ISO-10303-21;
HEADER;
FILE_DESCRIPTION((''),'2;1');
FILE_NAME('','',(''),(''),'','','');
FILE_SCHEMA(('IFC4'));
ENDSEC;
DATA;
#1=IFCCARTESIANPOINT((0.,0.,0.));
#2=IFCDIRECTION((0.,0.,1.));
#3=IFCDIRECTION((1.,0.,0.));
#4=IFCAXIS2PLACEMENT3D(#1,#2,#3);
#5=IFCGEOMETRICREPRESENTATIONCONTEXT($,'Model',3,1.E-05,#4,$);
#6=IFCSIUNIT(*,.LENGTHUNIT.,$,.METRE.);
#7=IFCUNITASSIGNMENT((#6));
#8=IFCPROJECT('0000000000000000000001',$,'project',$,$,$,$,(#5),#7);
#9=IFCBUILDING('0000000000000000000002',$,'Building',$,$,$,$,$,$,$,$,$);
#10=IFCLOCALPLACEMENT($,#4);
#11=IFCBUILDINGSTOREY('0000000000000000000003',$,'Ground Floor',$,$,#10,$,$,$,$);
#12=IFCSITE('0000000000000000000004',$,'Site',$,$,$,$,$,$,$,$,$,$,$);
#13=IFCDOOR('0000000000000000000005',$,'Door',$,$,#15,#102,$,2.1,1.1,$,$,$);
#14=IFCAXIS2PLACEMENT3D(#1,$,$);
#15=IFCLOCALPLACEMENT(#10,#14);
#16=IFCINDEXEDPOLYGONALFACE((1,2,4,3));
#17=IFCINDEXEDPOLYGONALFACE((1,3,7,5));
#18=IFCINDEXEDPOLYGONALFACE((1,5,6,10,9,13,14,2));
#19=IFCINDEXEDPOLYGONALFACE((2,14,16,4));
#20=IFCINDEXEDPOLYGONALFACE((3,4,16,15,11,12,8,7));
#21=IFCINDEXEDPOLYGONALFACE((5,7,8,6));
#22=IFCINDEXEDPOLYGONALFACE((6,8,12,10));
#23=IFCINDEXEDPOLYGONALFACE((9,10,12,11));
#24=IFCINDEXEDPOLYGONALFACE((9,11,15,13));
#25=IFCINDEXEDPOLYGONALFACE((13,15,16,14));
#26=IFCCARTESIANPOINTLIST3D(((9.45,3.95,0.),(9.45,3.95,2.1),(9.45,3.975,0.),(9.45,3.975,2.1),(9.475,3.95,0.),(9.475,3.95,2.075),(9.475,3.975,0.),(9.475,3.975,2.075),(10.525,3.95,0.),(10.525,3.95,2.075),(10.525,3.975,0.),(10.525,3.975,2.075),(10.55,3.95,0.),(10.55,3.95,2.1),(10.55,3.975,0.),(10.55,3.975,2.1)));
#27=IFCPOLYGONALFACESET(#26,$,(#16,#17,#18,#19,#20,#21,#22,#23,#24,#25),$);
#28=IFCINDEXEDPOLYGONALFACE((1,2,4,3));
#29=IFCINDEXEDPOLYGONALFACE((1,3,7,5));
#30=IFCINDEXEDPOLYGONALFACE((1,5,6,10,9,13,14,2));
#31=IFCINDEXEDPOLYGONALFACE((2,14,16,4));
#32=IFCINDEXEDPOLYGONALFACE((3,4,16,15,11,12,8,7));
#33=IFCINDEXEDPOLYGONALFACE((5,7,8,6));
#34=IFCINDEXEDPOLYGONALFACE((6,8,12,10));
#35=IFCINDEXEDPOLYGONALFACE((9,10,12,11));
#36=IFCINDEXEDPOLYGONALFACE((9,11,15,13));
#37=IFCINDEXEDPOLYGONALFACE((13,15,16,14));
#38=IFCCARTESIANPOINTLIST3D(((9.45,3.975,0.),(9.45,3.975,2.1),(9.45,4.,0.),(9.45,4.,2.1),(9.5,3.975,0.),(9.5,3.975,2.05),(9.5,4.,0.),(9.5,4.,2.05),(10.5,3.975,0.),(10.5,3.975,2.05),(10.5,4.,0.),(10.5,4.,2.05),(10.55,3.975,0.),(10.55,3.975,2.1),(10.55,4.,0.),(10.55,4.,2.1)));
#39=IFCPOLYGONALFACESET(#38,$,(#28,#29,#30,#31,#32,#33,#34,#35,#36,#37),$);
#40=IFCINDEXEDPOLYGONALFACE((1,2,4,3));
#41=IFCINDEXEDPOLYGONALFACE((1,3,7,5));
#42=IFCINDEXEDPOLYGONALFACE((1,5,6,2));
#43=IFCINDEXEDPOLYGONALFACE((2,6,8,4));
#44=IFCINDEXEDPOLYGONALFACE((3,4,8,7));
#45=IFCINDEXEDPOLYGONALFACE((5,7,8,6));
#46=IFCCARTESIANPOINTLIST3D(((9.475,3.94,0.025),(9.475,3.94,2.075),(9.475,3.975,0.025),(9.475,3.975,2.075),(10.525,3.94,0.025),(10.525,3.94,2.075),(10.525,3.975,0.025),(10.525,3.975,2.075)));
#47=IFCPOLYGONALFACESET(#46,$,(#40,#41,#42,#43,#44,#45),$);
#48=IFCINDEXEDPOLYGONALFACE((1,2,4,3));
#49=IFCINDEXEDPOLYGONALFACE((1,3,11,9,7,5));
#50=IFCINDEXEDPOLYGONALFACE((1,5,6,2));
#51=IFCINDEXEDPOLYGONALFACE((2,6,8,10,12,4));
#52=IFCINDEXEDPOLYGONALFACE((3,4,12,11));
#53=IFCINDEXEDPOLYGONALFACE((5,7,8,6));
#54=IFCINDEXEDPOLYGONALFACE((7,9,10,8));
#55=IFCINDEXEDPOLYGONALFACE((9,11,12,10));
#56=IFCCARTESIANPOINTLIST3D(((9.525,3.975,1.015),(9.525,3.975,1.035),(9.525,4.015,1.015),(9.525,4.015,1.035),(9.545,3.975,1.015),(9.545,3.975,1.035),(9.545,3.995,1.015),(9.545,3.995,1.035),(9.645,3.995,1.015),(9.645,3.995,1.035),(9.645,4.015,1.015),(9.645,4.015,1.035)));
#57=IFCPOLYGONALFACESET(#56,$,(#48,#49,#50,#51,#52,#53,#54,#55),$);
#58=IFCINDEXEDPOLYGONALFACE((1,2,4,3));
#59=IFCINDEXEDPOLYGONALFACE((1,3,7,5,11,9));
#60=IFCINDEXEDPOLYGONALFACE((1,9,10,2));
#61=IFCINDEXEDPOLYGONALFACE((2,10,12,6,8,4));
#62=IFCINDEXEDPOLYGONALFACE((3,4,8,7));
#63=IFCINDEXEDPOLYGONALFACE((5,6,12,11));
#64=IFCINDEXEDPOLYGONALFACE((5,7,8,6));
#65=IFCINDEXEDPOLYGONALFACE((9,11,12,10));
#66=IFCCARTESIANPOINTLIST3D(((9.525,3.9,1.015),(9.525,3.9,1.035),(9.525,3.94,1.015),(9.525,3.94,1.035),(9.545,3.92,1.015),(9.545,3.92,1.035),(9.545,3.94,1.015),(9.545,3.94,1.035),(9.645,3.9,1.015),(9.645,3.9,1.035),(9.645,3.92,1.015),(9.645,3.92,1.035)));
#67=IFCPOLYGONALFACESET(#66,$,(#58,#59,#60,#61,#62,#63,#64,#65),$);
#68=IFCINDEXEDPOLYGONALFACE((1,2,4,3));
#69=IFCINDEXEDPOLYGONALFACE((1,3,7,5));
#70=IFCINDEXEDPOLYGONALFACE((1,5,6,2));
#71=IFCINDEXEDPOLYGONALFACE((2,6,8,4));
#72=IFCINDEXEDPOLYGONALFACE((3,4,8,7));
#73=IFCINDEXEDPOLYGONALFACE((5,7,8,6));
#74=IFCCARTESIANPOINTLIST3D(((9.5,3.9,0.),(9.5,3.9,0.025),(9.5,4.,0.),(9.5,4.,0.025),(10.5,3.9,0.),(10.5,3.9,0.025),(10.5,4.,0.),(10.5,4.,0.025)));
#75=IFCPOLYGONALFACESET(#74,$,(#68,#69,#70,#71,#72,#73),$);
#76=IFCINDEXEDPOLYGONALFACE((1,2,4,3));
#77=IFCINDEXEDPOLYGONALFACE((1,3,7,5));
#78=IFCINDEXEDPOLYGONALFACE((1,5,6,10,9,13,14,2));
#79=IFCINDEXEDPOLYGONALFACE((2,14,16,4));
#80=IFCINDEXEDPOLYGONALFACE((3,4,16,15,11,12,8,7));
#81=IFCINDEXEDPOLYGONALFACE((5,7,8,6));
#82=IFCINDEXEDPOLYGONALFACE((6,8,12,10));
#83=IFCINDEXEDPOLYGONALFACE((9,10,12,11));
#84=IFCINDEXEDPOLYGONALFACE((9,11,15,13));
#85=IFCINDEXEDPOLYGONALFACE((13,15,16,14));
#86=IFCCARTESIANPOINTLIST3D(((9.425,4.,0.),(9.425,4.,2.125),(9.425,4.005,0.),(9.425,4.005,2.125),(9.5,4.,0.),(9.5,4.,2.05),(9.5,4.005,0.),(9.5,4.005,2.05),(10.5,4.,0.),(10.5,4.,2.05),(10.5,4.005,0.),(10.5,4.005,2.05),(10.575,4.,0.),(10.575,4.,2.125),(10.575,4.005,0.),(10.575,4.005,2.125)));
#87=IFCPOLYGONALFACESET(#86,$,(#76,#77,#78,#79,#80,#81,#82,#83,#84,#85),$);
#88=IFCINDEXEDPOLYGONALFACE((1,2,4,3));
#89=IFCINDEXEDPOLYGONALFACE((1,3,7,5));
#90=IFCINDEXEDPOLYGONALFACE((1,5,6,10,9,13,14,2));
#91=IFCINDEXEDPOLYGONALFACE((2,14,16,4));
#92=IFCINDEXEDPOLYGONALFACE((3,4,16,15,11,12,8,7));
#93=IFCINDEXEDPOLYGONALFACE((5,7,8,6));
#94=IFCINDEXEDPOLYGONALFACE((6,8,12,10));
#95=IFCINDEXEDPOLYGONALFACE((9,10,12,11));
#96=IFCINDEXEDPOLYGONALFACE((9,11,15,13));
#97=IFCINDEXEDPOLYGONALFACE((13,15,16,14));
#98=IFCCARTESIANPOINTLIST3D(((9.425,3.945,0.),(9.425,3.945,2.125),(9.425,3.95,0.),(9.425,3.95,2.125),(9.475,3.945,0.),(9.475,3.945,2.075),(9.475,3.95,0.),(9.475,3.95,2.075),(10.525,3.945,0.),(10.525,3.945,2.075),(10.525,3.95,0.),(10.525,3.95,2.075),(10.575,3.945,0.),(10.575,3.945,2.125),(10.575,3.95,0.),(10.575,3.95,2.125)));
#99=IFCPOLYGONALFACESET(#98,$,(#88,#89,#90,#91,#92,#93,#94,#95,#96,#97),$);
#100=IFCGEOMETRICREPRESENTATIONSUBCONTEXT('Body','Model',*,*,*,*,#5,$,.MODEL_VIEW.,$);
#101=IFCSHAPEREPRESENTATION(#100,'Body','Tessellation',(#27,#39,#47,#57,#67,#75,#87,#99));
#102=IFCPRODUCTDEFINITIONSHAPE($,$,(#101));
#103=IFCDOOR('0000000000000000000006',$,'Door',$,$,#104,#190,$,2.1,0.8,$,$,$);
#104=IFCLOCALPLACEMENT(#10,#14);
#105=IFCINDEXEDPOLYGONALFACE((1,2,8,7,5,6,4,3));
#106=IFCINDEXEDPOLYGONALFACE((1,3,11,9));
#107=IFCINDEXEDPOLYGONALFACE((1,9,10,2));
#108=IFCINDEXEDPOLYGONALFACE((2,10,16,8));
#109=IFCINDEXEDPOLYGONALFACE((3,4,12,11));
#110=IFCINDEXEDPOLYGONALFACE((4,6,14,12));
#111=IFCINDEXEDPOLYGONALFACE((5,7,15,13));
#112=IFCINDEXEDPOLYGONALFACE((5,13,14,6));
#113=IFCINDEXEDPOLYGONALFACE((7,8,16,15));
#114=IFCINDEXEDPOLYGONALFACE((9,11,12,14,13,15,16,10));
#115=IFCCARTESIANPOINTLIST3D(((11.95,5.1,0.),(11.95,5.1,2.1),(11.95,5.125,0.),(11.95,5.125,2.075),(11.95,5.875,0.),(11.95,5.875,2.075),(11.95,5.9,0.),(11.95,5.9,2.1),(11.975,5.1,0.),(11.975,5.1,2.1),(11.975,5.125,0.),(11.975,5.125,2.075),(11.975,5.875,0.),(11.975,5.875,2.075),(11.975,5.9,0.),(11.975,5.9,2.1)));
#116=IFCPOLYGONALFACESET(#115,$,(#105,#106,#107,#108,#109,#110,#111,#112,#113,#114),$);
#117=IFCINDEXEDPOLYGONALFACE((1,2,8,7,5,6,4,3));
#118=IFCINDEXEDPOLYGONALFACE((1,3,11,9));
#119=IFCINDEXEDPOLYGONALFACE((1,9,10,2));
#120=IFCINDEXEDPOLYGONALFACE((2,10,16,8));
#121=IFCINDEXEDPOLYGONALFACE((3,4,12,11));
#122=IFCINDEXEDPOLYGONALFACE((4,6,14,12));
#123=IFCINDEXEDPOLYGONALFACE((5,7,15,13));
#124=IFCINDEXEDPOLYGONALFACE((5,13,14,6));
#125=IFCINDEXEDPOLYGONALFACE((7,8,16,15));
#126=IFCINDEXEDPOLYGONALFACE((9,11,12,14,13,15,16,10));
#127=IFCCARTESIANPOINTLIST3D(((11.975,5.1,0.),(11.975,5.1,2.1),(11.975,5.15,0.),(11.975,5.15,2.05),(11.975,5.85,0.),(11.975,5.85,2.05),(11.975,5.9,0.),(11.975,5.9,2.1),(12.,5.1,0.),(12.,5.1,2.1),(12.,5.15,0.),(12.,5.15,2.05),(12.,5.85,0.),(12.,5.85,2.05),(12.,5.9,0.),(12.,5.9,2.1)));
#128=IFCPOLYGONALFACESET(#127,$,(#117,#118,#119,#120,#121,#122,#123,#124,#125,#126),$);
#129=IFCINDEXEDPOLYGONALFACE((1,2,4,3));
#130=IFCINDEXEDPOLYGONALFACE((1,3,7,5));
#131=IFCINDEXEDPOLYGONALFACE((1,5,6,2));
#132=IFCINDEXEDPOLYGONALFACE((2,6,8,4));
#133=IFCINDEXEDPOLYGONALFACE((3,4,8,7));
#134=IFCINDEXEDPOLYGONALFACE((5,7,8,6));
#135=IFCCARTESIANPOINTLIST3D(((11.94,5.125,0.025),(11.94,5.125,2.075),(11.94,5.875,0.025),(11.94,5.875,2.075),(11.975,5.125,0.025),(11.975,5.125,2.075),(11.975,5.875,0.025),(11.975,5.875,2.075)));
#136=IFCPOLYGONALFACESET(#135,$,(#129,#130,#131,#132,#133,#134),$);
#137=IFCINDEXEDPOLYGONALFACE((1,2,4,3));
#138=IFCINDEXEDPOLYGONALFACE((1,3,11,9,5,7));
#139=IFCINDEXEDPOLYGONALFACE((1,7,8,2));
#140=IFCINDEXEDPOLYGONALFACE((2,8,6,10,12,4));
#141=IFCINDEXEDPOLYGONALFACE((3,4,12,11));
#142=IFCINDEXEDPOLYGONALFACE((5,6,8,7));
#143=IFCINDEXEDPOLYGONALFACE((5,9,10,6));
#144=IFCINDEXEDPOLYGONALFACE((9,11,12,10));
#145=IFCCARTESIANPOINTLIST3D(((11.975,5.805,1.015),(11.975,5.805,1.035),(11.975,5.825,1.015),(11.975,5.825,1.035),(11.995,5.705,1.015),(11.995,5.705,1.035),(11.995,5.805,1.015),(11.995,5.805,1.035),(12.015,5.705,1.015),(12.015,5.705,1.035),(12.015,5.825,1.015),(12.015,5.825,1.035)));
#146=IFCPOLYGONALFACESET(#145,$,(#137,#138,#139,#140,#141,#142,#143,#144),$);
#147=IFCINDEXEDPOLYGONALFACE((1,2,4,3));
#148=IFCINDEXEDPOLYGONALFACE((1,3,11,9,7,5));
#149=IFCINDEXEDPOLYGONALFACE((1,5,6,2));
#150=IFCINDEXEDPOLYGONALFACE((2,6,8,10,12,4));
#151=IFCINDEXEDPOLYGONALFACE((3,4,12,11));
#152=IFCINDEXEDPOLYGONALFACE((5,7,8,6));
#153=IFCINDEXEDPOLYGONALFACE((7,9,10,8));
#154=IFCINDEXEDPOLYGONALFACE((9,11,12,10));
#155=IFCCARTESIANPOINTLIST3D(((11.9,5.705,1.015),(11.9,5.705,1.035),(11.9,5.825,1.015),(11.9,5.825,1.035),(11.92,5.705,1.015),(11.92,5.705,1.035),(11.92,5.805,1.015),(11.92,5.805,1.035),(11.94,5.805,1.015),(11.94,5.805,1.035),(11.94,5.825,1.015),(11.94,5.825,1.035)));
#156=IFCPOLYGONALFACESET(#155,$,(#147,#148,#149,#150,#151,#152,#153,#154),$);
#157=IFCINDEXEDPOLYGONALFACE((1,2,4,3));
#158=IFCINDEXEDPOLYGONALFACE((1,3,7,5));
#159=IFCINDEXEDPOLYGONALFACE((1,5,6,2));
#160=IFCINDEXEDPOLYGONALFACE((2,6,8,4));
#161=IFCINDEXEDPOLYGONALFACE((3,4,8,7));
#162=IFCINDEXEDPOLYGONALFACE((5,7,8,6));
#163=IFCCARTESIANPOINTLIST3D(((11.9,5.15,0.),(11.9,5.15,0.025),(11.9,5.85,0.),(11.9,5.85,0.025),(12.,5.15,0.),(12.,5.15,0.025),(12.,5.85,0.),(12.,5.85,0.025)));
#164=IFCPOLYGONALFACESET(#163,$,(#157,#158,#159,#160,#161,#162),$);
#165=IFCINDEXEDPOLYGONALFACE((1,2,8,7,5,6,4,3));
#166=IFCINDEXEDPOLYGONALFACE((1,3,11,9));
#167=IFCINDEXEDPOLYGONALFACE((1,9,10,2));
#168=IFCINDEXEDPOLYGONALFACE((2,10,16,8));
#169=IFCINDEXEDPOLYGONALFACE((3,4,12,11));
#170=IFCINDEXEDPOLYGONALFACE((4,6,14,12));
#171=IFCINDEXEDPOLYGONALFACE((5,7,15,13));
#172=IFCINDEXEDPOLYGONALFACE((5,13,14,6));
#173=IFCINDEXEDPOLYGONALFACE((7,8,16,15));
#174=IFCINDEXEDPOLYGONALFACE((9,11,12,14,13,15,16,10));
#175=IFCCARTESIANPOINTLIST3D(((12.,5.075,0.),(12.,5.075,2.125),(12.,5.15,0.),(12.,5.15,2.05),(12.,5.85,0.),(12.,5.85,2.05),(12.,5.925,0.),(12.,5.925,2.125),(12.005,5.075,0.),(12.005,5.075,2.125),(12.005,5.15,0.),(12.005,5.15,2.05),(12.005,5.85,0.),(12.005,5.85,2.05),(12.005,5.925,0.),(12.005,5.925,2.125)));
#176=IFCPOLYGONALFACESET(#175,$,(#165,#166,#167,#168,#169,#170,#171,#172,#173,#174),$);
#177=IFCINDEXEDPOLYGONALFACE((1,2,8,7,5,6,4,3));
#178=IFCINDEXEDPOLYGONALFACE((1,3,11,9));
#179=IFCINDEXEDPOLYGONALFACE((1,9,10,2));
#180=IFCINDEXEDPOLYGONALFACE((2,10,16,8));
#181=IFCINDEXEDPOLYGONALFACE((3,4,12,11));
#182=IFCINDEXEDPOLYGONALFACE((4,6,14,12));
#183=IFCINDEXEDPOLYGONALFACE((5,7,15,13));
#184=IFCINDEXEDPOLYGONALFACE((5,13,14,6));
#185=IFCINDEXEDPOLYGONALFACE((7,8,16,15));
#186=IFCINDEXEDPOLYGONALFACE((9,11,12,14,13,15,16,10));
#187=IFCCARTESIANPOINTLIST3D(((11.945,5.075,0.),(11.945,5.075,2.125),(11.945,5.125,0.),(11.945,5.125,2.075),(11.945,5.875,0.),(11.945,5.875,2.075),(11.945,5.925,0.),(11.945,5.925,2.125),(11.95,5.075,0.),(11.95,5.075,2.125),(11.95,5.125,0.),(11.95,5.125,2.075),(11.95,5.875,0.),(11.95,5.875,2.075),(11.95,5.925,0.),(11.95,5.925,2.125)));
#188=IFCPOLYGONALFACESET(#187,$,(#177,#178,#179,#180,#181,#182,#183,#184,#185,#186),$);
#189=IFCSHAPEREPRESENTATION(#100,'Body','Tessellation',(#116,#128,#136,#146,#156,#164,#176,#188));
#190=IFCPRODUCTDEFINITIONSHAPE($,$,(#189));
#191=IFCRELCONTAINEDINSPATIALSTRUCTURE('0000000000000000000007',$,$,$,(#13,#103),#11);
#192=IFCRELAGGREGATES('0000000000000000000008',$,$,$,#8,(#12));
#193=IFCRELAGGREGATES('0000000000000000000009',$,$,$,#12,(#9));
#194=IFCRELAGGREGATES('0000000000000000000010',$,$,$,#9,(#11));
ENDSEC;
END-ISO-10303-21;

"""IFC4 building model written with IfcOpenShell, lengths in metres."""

from ifc_helpers import new_model, si_unit, frame, origin_with_axes, place, context, subcontext, project, spatial, line, indexed_curve, outline, extrude, element, save


model = new_model("IFC4")

# Units and contexts
model_context = context("Model", 3, precision=1e-05, world=origin_with_axes())
body_context = subcontext(model_context, "Body", "Model", "MODEL_VIEW")
ifc_project = project(units=[si_unit("LENGTHUNIT", "METRE")], contexts=[model_context])

# Site, building, storey
site = spatial("IfcSite", under=ifc_project, Name="Site")
building = spatial("IfcBuilding", under=site, Name="Building")
storey_placement = place(None, origin_with_axes())
storey = spatial("IfcBuildingStorey", under=building, at=storey_placement, Name="Ground Floor")

# Doors
door_1_placement = place(storey_placement, frame((10.55, 4.0, 0.0), z_axis=(0.0, 0.0, 1.0), x_axis=(-1.0, 0.0, 0.0)))
element("IfcDoor", 1, at=door_1_placement, inside=storey, Name="Door", OverallHeight=2.1, OverallWidth=1.1, context=body_context, shape_type="SweptSolid", body=[
    extrude(outline(indexed_curve([(0.0, 0.0), (0.0, 2.1), (1.1, 2.1), (1.1, 0.0), (1.075, 0.0), (1.075, 2.075), (0.025, 2.075), (0.025, 0.0)], segments=[line(1, 2, 3, 4, 5, 6, 7, 8, 1)])), frame((0.0, 0.025, 0.0), z_axis=(0.0, -1.0, 0.0), x_axis=(1.0, 0.0, 0.0)), (0.0, 0.0, -1.0), 0.025),
    extrude(outline(indexed_curve([(0.0, 0.0), (0.0, 2.1), (1.1, 2.1), (1.1, 0.0), (1.05, 0.0), (1.05, 2.05), (0.05, 2.05), (0.05, 0.0)], segments=[line(1, 2, 3, 4, 5, 6, 7, 8, 1)])), frame((0.0, 0.0, 0.0), z_axis=(0.0, -1.0, 0.0), x_axis=(1.0, 0.0, 0.0)), (0.0, 0.0, -1.0), 0.025),
    extrude(outline(indexed_curve([(0.0, 0.0), (1.05, 0.0), (1.05, 0.035), (0.0, 0.035)], segments=[line(1, 2, 3, 4, 1)])), frame((0.025, 0.025, 0.025), z_axis=(0.0, 0.0, 1.0), x_axis=(1.0, 0.0, 0.0)), (0.0, 0.0, 1.0), 2.05),
    extrude(outline(indexed_curve([(0.0, 0.0), (0.0, -0.04), (-0.12, -0.04), (-0.12, -0.02), (-0.02, -0.02), (-0.02, 0.0)], segments=[line(1, 2, 3, 4, 5, 6, 1)])), frame((1.025, 0.025, 1.015), z_axis=(0.0, 0.0, 1.0), x_axis=(1.0, 0.0, 0.0)), (0.0, 0.0, 1.0), 0.02),
    extrude(outline(indexed_curve([(0.0, 0.0), (0.0, 0.04), (-0.12, 0.04), (-0.12, 0.02), (-0.02, 0.02), (-0.02, 0.0)], segments=[line(1, 2, 3, 4, 5, 6, 1)])), frame((1.025, 0.06, 1.015), z_axis=(0.0, 0.0, 1.0), x_axis=(1.0, 0.0, 0.0)), (0.0, 0.0, 1.0), 0.02),
    extrude(outline(indexed_curve([(0.0, 0.0), (1.0, 0.0), (1.0, 0.1), (0.0, 0.1)], segments=[line(1, 2, 3, 4, 1)])), frame((0.05, 0.0, 0.0), z_axis=(0.0, 0.0, 1.0), x_axis=(1.0, 0.0, 0.0)), (0.0, 0.0, 1.0), 0.025),
    extrude(outline(indexed_curve([(0.0, 0.0), (0.0, 2.125), (1.15, 2.125), (1.15, 0.0), (1.075, 0.0), (1.075, 2.05), (0.075, 2.05), (0.075, 0.0)], segments=[line(1, 2, 3, 4, 5, 6, 7, 8, 1)])), frame((-0.025, -0.005, 0.0), z_axis=(0.0, -1.0, 0.0), x_axis=(1.0, 0.0, 0.0)), (0.0, 0.0, -1.0), 0.005),
    extrude(outline(indexed_curve([(0.0, 0.0), (0.0, 2.125), (1.15, 2.125), (1.15, 0.0), (1.1, 0.0), (1.1, 2.075), (0.05, 2.075), (0.05, 0.0)], segments=[line(1, 2, 3, 4, 5, 6, 7, 8, 1)])), frame((-0.025, 0.05, 0.0), z_axis=(0.0, -1.0, 0.0), x_axis=(1.0, 0.0, 0.0)), (0.0, 0.0, -1.0), 0.005),
])
door_2_placement = place(storey_placement, frame((12.0, 5.1, 0.0), z_axis=(0.0, 0.0, 1.0), x_axis=(0.0, 1.0, 0.0)))
element("IfcDoor", 2, at=door_2_placement, inside=storey, Name="Door", OverallHeight=2.1, OverallWidth=0.8, context=body_context, shape_type="SweptSolid", body=[
    extrude(outline(indexed_curve([(0.0, 0.0), (0.0, 2.1), (0.8, 2.1), (0.8, 0.0), (0.775, 0.0), (0.775, 2.075), (0.025, 2.075), (0.025, 0.0)], segments=[line(1, 2, 3, 4, 5, 6, 7, 8, 1)])), frame((0.0, 0.025, 0.0), z_axis=(0.0, -1.0, 0.0), x_axis=(1.0, 0.0, 0.0)), (0.0, 0.0, -1.0), 0.025),
    extrude(outline(indexed_curve([(0.0, 0.0), (0.0, 2.1), (0.8, 2.1), (0.8, 0.0), (0.75, 0.0), (0.75, 2.05), (0.05, 2.05), (0.05, 0.0)], segments=[line(1, 2, 3, 4, 5, 6, 7, 8, 1)])), frame((0.0, 0.0, 0.0), z_axis=(0.0, -1.0, 0.0), x_axis=(1.0, 0.0, 0.0)), (0.0, 0.0, -1.0), 0.025),
    extrude(outline(indexed_curve([(0.0, 0.0), (0.75, 0.0), (0.75, 0.035), (0.0, 0.035)], segments=[line(1, 2, 3, 4, 1)])), frame((0.025, 0.025, 0.025), z_axis=(0.0, 0.0, 1.0), x_axis=(1.0, 0.0, 0.0)), (0.0, 0.0, 1.0), 2.05),
    extrude(outline(indexed_curve([(0.0, 0.0), (0.0, -0.04), (-0.12, -0.04), (-0.12, -0.02), (-0.02, -0.02), (-0.02, 0.0)], segments=[line(1, 2, 3, 4, 5, 6, 1)])), frame((0.725, 0.025, 1.015), z_axis=(0.0, 0.0, 1.0), x_axis=(1.0, 0.0, 0.0)), (0.0, 0.0, 1.0), 0.02),
    extrude(outline(indexed_curve([(0.0, 0.0), (0.0, 0.04), (-0.12, 0.04), (-0.12, 0.02), (-0.02, 0.02), (-0.02, 0.0)], segments=[line(1, 2, 3, 4, 5, 6, 1)])), frame((0.725, 0.06, 1.015), z_axis=(0.0, 0.0, 1.0), x_axis=(1.0, 0.0, 0.0)), (0.0, 0.0, 1.0), 0.02),
    extrude(outline(indexed_curve([(0.0, 0.0), (0.7, 0.0), (0.7, 0.1), (0.0, 0.1)], segments=[line(1, 2, 3, 4, 1)])), frame((0.05, 0.0, 0.0), z_axis=(0.0, 0.0, 1.0), x_axis=(1.0, 0.0, 0.0)), (0.0, 0.0, 1.0), 0.025),
    extrude(outline(indexed_curve([(0.0, 0.0), (0.0, 2.125), (0.85, 2.125), (0.85, 0.0), (0.775, 0.0), (0.775, 2.05), (0.075, 2.05), (0.075, 0.0)], segments=[line(1, 2, 3, 4, 5, 6, 7, 8, 1)])), frame((-0.025, -0.005, 0.0), z_axis=(0.0, -1.0, 0.0), x_axis=(1.0, 0.0, 0.0)), (0.0, 0.0, -1.0), 0.005),
    extrude(outline(indexed_curve([(0.0, 0.0), (0.0, 2.125), (0.85, 2.125), (0.85, 0.0), (0.8, 0.0), (0.8, 2.075), (0.05, 2.075), (0.05, 0.0)], segments=[line(1, 2, 3, 4, 5, 6, 7, 8, 1)])), frame((-0.025, 0.05, 0.0), z_axis=(0.0, -1.0, 0.0), x_axis=(1.0, 0.0, 0.0)), (0.0, 0.0, -1.0), 0.005),
])

save(model, "model.ifc")
